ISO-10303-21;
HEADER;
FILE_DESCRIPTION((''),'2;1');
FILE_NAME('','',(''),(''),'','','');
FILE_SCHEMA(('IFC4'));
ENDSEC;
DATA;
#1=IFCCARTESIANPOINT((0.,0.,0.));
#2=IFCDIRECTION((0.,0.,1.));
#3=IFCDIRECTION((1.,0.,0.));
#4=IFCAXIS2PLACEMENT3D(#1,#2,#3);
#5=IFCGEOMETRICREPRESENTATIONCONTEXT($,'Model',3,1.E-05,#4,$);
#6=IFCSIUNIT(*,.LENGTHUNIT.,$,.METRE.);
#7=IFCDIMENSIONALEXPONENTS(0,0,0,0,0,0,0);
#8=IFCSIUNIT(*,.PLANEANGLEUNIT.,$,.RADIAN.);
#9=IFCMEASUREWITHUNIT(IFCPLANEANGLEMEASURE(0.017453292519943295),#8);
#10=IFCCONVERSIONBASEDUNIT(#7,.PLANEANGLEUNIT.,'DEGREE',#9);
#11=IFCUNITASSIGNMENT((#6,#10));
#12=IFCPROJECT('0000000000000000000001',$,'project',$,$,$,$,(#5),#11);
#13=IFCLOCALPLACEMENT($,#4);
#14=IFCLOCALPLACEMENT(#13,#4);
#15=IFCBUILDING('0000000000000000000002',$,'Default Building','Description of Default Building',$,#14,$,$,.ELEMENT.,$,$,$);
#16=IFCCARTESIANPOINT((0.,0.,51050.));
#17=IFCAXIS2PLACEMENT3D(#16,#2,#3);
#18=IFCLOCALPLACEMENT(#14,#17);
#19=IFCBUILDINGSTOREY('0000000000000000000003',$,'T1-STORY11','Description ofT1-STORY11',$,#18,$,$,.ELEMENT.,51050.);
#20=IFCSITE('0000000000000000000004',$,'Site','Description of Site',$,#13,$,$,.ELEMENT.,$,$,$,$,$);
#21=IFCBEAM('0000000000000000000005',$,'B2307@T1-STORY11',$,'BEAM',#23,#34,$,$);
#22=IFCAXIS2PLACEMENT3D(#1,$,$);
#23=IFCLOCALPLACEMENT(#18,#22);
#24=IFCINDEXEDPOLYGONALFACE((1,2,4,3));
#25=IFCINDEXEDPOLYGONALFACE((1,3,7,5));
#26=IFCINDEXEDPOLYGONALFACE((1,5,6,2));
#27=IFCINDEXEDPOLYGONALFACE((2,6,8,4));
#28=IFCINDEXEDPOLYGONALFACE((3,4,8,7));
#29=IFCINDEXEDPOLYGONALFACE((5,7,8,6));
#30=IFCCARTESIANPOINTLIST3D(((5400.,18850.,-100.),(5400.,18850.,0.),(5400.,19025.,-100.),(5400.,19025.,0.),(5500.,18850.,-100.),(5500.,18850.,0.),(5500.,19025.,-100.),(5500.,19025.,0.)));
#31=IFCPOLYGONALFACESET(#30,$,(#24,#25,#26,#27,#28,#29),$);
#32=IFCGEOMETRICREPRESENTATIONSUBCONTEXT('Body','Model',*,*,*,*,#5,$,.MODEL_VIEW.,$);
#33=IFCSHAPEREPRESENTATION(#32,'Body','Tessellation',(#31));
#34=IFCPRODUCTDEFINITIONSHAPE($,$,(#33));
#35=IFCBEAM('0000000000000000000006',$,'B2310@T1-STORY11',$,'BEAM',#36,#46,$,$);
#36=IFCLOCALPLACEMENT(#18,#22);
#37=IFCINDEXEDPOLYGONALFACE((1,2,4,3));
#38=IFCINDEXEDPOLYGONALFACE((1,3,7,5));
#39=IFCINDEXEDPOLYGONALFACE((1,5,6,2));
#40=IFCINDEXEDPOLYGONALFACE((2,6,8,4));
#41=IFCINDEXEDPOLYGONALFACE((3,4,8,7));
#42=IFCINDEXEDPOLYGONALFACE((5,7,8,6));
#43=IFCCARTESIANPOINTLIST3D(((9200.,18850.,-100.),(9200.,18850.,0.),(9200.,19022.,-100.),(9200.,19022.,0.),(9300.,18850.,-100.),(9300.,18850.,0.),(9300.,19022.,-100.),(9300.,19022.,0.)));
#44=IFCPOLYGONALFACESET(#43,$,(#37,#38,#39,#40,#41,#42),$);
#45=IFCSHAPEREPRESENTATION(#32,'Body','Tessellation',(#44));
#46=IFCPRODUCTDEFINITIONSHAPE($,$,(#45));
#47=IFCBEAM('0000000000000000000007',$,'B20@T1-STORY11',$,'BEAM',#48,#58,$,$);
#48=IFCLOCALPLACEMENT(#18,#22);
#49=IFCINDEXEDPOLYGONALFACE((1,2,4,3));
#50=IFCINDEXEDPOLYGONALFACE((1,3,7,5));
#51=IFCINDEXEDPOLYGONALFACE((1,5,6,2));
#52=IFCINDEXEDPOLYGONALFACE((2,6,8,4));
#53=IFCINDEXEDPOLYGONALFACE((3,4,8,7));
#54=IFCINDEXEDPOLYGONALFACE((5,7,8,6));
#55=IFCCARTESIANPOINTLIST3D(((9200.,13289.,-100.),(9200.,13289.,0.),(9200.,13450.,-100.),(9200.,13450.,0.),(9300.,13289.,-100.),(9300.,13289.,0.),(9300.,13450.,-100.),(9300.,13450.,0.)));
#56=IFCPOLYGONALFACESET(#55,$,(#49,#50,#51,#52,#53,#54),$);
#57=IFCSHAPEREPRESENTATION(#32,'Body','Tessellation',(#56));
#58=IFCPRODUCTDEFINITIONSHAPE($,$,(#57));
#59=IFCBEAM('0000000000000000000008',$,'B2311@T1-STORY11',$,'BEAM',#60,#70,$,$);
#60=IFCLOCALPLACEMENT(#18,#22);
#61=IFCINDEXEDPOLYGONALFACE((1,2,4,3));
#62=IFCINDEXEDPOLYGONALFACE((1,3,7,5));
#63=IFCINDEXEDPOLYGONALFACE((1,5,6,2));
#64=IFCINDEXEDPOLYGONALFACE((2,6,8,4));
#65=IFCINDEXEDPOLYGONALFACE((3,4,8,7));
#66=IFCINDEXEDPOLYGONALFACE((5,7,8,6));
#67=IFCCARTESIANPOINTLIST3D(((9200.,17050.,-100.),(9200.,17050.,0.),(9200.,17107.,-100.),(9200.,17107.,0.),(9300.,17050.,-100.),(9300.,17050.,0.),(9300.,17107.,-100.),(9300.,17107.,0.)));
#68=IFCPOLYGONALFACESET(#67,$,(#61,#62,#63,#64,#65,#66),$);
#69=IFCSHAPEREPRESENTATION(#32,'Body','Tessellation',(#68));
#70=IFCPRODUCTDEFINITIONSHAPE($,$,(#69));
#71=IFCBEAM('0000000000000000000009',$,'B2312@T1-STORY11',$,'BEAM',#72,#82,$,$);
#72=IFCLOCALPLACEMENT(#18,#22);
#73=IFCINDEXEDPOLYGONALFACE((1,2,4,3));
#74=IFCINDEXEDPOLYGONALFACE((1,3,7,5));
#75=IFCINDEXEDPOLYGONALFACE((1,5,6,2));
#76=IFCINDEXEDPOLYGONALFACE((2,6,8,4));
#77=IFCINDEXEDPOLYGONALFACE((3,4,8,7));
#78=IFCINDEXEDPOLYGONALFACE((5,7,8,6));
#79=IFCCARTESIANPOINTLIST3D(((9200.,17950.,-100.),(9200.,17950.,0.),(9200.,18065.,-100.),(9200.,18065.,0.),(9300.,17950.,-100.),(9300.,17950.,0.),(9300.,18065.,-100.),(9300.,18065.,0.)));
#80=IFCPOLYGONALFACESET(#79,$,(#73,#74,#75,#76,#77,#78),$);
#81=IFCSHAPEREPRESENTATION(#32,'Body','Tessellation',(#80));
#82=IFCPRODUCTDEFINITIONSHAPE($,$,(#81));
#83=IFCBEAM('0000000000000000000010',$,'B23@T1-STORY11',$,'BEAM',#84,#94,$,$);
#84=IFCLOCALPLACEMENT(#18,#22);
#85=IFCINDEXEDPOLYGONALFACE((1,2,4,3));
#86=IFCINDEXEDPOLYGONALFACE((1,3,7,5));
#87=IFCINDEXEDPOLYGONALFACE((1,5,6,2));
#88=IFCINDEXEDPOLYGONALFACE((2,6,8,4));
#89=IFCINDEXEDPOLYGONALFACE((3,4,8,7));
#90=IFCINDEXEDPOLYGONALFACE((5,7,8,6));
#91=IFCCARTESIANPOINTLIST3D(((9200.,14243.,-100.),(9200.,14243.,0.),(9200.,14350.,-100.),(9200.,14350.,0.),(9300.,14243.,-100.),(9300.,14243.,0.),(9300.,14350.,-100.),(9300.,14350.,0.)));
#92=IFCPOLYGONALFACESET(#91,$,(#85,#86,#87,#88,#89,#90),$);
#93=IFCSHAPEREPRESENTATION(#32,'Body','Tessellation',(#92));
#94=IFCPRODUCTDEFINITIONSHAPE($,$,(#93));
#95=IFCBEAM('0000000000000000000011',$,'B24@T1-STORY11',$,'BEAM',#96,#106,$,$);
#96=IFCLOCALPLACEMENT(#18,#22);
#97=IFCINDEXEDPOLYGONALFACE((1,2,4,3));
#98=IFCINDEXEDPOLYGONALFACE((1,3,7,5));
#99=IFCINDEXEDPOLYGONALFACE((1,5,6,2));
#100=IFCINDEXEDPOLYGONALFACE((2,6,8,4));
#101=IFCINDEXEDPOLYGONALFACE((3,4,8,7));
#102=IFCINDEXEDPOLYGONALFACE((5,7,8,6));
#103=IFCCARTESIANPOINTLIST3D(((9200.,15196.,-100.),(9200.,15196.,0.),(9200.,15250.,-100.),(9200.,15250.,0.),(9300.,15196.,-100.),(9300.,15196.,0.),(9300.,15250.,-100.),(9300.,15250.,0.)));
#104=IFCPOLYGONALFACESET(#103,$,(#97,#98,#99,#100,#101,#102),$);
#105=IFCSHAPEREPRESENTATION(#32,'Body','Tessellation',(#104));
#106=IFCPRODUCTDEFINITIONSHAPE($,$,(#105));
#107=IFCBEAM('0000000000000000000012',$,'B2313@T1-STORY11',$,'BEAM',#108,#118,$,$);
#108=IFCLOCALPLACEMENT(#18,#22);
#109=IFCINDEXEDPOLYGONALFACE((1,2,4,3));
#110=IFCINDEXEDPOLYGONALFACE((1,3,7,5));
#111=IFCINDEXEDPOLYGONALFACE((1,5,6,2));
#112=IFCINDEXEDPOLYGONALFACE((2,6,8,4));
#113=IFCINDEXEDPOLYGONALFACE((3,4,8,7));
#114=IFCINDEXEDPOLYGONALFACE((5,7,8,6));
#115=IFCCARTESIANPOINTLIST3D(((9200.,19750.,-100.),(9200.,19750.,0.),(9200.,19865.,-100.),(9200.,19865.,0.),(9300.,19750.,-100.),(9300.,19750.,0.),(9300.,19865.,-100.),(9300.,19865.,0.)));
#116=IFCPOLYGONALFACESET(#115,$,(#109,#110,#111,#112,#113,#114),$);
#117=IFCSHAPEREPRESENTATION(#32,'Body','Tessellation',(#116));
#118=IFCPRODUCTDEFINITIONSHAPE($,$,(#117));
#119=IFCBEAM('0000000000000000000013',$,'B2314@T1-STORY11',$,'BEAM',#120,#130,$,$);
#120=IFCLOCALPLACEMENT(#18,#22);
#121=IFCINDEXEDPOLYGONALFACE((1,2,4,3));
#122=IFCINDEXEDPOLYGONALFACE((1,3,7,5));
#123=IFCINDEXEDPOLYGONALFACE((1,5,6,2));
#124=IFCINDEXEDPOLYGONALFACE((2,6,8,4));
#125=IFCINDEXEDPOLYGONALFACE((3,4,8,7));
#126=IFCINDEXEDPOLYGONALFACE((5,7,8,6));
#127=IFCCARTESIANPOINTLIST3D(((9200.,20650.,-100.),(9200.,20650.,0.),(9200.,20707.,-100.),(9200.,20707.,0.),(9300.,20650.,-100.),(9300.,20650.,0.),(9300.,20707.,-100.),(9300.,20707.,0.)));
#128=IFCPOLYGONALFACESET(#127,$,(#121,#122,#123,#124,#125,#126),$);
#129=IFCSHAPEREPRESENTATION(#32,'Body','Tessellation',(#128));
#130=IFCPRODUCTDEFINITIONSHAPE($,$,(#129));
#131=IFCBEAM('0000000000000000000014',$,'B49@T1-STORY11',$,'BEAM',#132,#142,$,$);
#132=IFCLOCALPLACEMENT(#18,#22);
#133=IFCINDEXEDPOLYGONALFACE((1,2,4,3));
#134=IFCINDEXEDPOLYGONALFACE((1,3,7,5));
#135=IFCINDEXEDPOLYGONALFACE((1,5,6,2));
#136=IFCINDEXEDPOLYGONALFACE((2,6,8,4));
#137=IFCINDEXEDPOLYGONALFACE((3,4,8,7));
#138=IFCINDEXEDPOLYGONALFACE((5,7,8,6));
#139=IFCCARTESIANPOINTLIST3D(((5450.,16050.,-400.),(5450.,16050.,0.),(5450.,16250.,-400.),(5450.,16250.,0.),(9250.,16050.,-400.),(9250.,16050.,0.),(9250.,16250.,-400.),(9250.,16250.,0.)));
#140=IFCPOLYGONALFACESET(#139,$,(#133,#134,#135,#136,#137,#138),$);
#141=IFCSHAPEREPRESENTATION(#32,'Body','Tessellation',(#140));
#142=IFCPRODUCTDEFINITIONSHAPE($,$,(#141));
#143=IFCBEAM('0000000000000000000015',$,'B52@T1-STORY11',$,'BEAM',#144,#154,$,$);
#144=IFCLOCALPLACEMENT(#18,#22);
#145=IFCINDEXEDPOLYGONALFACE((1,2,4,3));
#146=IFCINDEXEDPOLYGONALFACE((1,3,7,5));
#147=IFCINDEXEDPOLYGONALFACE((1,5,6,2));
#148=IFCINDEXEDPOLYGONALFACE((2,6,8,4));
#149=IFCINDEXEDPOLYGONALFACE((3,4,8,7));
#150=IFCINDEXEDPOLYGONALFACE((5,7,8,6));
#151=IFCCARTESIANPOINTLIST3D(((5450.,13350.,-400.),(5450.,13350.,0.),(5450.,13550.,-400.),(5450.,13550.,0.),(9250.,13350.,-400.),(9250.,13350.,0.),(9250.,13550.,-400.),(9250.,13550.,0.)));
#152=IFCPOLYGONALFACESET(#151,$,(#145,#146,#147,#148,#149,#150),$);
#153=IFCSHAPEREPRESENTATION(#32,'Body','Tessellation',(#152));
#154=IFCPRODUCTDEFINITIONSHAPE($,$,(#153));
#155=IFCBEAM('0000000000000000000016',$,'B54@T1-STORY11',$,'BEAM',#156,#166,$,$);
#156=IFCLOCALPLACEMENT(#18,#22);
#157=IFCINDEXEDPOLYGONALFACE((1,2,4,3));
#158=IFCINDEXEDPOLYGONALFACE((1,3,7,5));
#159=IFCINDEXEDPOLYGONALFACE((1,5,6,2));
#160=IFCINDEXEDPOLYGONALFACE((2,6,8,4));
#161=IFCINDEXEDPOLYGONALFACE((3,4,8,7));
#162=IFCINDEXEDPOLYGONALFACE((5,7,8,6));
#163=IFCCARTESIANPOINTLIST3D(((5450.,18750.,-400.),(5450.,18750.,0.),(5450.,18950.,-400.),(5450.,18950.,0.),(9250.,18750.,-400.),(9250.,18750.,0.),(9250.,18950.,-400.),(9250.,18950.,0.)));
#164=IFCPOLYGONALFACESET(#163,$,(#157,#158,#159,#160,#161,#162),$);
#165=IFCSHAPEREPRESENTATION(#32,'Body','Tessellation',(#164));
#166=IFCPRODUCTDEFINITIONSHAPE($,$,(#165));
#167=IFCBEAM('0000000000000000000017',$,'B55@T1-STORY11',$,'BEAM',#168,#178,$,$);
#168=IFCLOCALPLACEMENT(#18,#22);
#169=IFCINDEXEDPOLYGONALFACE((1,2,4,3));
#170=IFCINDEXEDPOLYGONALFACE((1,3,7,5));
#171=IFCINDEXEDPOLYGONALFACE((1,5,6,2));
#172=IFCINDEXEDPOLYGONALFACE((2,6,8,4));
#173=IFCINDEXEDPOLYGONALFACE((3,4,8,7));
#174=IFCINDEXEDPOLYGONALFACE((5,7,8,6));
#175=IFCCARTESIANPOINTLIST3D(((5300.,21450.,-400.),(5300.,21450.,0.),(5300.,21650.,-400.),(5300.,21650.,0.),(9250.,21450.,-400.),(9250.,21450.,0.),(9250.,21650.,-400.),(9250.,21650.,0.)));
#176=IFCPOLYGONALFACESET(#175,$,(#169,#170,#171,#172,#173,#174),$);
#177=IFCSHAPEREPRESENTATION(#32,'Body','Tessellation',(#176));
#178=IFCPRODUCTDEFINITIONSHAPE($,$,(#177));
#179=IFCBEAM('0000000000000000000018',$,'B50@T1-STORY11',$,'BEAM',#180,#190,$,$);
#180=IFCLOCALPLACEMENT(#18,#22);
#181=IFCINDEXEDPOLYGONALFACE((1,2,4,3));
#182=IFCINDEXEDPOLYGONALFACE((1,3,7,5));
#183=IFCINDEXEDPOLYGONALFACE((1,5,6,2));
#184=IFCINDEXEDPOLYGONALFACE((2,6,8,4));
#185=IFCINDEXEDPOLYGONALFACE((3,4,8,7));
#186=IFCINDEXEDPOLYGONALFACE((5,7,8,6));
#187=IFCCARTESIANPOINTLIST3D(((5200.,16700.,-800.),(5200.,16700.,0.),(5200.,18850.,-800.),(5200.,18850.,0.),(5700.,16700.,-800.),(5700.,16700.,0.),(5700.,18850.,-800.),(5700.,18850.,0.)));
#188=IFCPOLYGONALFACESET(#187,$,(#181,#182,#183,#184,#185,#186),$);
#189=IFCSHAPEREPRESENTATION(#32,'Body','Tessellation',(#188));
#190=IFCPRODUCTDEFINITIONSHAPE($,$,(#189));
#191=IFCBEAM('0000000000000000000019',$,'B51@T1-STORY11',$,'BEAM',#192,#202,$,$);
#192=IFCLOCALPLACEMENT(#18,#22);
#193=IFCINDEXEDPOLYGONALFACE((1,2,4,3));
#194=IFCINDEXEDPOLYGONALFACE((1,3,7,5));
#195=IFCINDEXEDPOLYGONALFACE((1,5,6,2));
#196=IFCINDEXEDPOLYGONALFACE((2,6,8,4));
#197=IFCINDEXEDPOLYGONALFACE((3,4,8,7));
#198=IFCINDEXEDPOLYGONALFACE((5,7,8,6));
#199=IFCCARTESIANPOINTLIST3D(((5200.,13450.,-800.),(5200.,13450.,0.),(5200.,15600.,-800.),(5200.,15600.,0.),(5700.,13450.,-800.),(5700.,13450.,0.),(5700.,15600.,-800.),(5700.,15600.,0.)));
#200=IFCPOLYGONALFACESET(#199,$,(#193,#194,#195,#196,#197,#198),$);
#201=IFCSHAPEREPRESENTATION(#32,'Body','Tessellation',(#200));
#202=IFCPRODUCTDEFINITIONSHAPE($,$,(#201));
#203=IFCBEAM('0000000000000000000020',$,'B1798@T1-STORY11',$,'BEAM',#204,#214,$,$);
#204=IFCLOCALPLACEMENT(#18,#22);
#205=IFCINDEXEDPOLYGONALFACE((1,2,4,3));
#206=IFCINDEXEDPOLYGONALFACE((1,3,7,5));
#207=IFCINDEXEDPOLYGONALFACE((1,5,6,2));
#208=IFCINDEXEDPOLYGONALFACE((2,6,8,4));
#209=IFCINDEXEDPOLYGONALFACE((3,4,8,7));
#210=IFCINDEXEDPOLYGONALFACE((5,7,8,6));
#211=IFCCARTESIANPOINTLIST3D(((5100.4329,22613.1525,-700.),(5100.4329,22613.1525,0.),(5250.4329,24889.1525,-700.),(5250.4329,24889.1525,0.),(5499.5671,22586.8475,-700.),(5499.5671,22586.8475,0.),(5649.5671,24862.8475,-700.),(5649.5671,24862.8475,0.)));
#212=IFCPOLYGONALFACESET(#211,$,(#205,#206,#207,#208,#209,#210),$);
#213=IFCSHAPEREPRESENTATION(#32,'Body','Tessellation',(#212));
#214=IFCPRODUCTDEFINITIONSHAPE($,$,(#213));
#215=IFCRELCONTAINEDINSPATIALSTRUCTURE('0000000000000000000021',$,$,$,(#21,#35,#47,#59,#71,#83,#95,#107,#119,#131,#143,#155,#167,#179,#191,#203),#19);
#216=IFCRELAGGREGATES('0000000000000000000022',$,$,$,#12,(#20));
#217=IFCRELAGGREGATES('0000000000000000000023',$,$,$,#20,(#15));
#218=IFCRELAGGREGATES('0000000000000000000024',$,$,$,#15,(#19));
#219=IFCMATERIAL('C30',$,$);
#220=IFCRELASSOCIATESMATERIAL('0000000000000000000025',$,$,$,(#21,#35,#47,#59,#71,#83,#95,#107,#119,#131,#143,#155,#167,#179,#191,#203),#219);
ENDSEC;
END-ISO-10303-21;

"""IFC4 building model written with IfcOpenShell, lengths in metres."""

from ifc_helpers import new_model, entity, si_unit, converted_unit, frame, origin_with_axes, place, context, subcontext, project, spatial, rectangle, extrude, material, element, save


model = new_model("IFC4")

# Units and contexts
model_context = context("Model", 3, precision=1e-05, world=origin_with_axes())
body_context = subcontext(model_context, "Body", "Model", "MODEL_VIEW")
ifc_project = project(units=[si_unit("LENGTHUNIT", "METRE"), converted_unit("PLANEANGLEUNIT", "DEGREE", entity("IfcPlaneAngleMeasure", 0.017453292519943295), si_unit("PLANEANGLEUNIT", "RADIAN"), dimensions=[0, 0, 0, 0, 0, 0, 0])], contexts=[model_context])

# Site, building, storey
site_placement = place(None, origin_with_axes())
site = spatial("IfcSite", under=ifc_project, at=site_placement, Name="Site", Description="Description of Site", CompositionType="ELEMENT")
building_placement = place(site_placement, origin_with_axes())
building = spatial("IfcBuilding", under=site, at=building_placement, Name="Default Building", Description="Description of Default Building", CompositionType="ELEMENT")
storey_placement = place(building_placement, frame((0.0, 0.0, 51050.0), z_axis=(0.0, 0.0, 1.0), x_axis=(1.0, 0.0, 0.0)))
storey = spatial("IfcBuildingStorey", under=building, at=storey_placement, Name="T1-STORY11", Description="Description ofT1-STORY11", CompositionType="ELEMENT", Elevation=51050.0)

# Beams
ifc_material_1 = material(Name="C30")
beam_1_placement = place(storey_placement, frame((5450.0, 18850.0, -50.0), z_axis=(0.0, 1.0, 0.0), x_axis=(-1.0, 0.0, 0.0)))
element("IfcBeam", 1, at=beam_1_placement, inside=storey, material=ifc_material_1, Name="B2307@T1-STORY11", ObjectType="BEAM", context=body_context, shape_type="SweptSolid", body=[
    extrude(rectangle(XDim=100.0, YDim=100.0), origin_with_axes(), (0.0, 0.0, 1.0), 175.0),
])
beam_2_placement = place(storey_placement, frame((9250.0, 18850.0, -50.0), z_axis=(0.0, 1.0, 0.0), x_axis=(-1.0, 0.0, 0.0)))
element("IfcBeam", 2, at=beam_2_placement, inside=storey, material=ifc_material_1, Name="B2310@T1-STORY11", ObjectType="BEAM", context=body_context, shape_type="SweptSolid", body=[
    extrude(rectangle(XDim=100.0, YDim=100.0), origin_with_axes(), (0.0, 0.0, 1.0), 172.0),
])
beam_3_placement = place(storey_placement, frame((9250.0, 13289.0, -50.0), z_axis=(0.0, 1.0, 0.0), x_axis=(-1.0, 0.0, 0.0)))
element("IfcBeam", 3, at=beam_3_placement, inside=storey, material=ifc_material_1, Name="B20@T1-STORY11", ObjectType="BEAM", context=body_context, shape_type="SweptSolid", body=[
    extrude(rectangle(XDim=100.0, YDim=100.0), origin_with_axes(), (0.0, 0.0, 1.0), 161.0),
])
beam_4_placement = place(storey_placement, frame((9250.0, 17050.0, -50.0), z_axis=(0.0, 1.0, 0.0), x_axis=(-1.0, 0.0, 0.0)))
element("IfcBeam", 4, at=beam_4_placement, inside=storey, material=ifc_material_1, Name="B2311@T1-STORY11", ObjectType="BEAM", context=body_context, shape_type="SweptSolid", body=[
    extrude(rectangle(XDim=100.0, YDim=100.0), origin_with_axes(), (0.0, 0.0, 1.0), 57.0),
])
beam_5_placement = place(storey_placement, frame((9250.0, 17950.0, -50.0), z_axis=(0.0, 1.0, 0.0), x_axis=(-1.0, 0.0, 0.0)))
element("IfcBeam", 5, at=beam_5_placement, inside=storey, material=ifc_material_1, Name="B2312@T1-STORY11", ObjectType="BEAM", context=body_context, shape_type="SweptSolid", body=[
    extrude(rectangle(XDim=100.0, YDim=100.0), origin_with_axes(), (0.0, 0.0, 1.0), 115.0),
])
beam_6_placement = place(storey_placement, frame((9250.0, 14243.0, -50.0), z_axis=(0.0, 1.0, 0.0), x_axis=(-1.0, 0.0, 0.0)))
element("IfcBeam", 6, at=beam_6_placement, inside=storey, material=ifc_material_1, Name="B23@T1-STORY11", ObjectType="BEAM", context=body_context, shape_type="SweptSolid", body=[
    extrude(rectangle(XDim=100.0, YDim=100.0), origin_with_axes(), (0.0, 0.0, 1.0), 107.0),
])
beam_7_placement = place(storey_placement, frame((9250.0, 15196.0, -50.0), z_axis=(0.0, 1.0, 0.0), x_axis=(-1.0, 0.0, 0.0)))
element("IfcBeam", 7, at=beam_7_placement, inside=storey, material=ifc_material_1, Name="B24@T1-STORY11", ObjectType="BEAM", context=body_context, shape_type="SweptSolid", body=[
    extrude(rectangle(XDim=100.0, YDim=100.0), origin_with_axes(), (0.0, 0.0, 1.0), 54.0),
])
beam_8_placement = place(storey_placement, frame((9250.0, 19750.0, -50.0), z_axis=(0.0, 1.0, 0.0), x_axis=(-1.0, 0.0, 0.0)))
element("IfcBeam", 8, at=beam_8_placement, inside=storey, material=ifc_material_1, Name="B2313@T1-STORY11", ObjectType="BEAM", context=body_context, shape_type="SweptSolid", body=[
    extrude(rectangle(XDim=100.0, YDim=100.0), origin_with_axes(), (0.0, 0.0, 1.0), 115.0),
])
beam_9_placement = place(storey_placement, frame((9250.0, 20650.0, -50.0), z_axis=(0.0, 1.0, 0.0), x_axis=(-1.0, 0.0, 0.0)))
element("IfcBeam", 9, at=beam_9_placement, inside=storey, material=ifc_material_1, Name="B2314@T1-STORY11", ObjectType="BEAM", context=body_context, shape_type="SweptSolid", body=[
    extrude(rectangle(XDim=100.0, YDim=100.0), origin_with_axes(), (0.0, 0.0, 1.0), 57.0),
])
for number, where, z_axis, x_axis, name in (
    (10, (5450.0, 16150.0, -200.0), (1.0, 0.0, 0.0), (0.0, 1.0, 0.0), "B49@T1-STORY11"),
    (11, (5450.0, 13450.0, -200.0), (1.0, 0.0, 0.0), (0.0, 1.0, 0.0), "B52@T1-STORY11"),
    (12, (5450.0, 18850.0, -200.0), (1.0, 0.0, 0.0), (0.0, 1.0, 0.0), "B54@T1-STORY11"),
):
    element("IfcBeam", number, at=place(storey_placement, frame(where, z_axis=z_axis, x_axis=x_axis)), inside=storey, material=ifc_material_1, Name=name, ObjectType="BEAM", context=body_context, shape_type="SweptSolid", body=[
        extrude(rectangle(XDim=200.0, YDim=400.0), origin_with_axes(), (0.0, 0.0, 1.0), 3800.0),
    ])
beam_10_placement = place(storey_placement, frame((5300.0, 21550.0, -200.0), z_axis=(1.0, 0.0, 0.0), x_axis=(0.0, 1.0, 0.0)))
element("IfcBeam", 13, at=beam_10_placement, inside=storey, material=ifc_material_1, Name="B55@T1-STORY11", ObjectType="BEAM", context=body_context, shape_type="SweptSolid", body=[
    extrude(rectangle(XDim=200.0, YDim=400.0), origin_with_axes(), (0.0, 0.0, 1.0), 3950.0),
])
for number, where, z_axis, x_axis, name in (
    (14, (5450.0, 16700.0, -400.0), (0.0, 1.0, 0.0), (-1.0, 0.0, 0.0), "B50@T1-STORY11"),
    (15, (5450.0, 13450.0, -400.0), (0.0, 1.0, 0.0), (-1.0, 0.0, 0.0), "B51@T1-STORY11"),
):
    element("IfcBeam", number, at=place(storey_placement, frame(where, z_axis=z_axis, x_axis=x_axis)), inside=storey, material=ifc_material_1, Name=name, ObjectType="BEAM", context=body_context, shape_type="SweptSolid", body=[
        extrude(rectangle(XDim=500.0, YDim=800.0), origin_with_axes(), (0.0, 0.0, 1.0), 2150.0),
    ])
beam_11_placement = place(storey_placement, frame((5300.0, 22600.0, -350.0), z_axis=(0.065762, 0.997835, 0.0), x_axis=(-0.997835, 0.065762, 0.0)))
element("IfcBeam", 16, at=beam_11_placement, inside=storey, material=ifc_material_1, Name="B1798@T1-STORY11", ObjectType="BEAM", context=body_context, shape_type="SweptSolid", body=[
    extrude(rectangle(XDim=400.0, YDim=700.0), origin_with_axes(), (0.0, 0.0, 1.0), 2280.9375),
])

save(model, "model.ifc")
